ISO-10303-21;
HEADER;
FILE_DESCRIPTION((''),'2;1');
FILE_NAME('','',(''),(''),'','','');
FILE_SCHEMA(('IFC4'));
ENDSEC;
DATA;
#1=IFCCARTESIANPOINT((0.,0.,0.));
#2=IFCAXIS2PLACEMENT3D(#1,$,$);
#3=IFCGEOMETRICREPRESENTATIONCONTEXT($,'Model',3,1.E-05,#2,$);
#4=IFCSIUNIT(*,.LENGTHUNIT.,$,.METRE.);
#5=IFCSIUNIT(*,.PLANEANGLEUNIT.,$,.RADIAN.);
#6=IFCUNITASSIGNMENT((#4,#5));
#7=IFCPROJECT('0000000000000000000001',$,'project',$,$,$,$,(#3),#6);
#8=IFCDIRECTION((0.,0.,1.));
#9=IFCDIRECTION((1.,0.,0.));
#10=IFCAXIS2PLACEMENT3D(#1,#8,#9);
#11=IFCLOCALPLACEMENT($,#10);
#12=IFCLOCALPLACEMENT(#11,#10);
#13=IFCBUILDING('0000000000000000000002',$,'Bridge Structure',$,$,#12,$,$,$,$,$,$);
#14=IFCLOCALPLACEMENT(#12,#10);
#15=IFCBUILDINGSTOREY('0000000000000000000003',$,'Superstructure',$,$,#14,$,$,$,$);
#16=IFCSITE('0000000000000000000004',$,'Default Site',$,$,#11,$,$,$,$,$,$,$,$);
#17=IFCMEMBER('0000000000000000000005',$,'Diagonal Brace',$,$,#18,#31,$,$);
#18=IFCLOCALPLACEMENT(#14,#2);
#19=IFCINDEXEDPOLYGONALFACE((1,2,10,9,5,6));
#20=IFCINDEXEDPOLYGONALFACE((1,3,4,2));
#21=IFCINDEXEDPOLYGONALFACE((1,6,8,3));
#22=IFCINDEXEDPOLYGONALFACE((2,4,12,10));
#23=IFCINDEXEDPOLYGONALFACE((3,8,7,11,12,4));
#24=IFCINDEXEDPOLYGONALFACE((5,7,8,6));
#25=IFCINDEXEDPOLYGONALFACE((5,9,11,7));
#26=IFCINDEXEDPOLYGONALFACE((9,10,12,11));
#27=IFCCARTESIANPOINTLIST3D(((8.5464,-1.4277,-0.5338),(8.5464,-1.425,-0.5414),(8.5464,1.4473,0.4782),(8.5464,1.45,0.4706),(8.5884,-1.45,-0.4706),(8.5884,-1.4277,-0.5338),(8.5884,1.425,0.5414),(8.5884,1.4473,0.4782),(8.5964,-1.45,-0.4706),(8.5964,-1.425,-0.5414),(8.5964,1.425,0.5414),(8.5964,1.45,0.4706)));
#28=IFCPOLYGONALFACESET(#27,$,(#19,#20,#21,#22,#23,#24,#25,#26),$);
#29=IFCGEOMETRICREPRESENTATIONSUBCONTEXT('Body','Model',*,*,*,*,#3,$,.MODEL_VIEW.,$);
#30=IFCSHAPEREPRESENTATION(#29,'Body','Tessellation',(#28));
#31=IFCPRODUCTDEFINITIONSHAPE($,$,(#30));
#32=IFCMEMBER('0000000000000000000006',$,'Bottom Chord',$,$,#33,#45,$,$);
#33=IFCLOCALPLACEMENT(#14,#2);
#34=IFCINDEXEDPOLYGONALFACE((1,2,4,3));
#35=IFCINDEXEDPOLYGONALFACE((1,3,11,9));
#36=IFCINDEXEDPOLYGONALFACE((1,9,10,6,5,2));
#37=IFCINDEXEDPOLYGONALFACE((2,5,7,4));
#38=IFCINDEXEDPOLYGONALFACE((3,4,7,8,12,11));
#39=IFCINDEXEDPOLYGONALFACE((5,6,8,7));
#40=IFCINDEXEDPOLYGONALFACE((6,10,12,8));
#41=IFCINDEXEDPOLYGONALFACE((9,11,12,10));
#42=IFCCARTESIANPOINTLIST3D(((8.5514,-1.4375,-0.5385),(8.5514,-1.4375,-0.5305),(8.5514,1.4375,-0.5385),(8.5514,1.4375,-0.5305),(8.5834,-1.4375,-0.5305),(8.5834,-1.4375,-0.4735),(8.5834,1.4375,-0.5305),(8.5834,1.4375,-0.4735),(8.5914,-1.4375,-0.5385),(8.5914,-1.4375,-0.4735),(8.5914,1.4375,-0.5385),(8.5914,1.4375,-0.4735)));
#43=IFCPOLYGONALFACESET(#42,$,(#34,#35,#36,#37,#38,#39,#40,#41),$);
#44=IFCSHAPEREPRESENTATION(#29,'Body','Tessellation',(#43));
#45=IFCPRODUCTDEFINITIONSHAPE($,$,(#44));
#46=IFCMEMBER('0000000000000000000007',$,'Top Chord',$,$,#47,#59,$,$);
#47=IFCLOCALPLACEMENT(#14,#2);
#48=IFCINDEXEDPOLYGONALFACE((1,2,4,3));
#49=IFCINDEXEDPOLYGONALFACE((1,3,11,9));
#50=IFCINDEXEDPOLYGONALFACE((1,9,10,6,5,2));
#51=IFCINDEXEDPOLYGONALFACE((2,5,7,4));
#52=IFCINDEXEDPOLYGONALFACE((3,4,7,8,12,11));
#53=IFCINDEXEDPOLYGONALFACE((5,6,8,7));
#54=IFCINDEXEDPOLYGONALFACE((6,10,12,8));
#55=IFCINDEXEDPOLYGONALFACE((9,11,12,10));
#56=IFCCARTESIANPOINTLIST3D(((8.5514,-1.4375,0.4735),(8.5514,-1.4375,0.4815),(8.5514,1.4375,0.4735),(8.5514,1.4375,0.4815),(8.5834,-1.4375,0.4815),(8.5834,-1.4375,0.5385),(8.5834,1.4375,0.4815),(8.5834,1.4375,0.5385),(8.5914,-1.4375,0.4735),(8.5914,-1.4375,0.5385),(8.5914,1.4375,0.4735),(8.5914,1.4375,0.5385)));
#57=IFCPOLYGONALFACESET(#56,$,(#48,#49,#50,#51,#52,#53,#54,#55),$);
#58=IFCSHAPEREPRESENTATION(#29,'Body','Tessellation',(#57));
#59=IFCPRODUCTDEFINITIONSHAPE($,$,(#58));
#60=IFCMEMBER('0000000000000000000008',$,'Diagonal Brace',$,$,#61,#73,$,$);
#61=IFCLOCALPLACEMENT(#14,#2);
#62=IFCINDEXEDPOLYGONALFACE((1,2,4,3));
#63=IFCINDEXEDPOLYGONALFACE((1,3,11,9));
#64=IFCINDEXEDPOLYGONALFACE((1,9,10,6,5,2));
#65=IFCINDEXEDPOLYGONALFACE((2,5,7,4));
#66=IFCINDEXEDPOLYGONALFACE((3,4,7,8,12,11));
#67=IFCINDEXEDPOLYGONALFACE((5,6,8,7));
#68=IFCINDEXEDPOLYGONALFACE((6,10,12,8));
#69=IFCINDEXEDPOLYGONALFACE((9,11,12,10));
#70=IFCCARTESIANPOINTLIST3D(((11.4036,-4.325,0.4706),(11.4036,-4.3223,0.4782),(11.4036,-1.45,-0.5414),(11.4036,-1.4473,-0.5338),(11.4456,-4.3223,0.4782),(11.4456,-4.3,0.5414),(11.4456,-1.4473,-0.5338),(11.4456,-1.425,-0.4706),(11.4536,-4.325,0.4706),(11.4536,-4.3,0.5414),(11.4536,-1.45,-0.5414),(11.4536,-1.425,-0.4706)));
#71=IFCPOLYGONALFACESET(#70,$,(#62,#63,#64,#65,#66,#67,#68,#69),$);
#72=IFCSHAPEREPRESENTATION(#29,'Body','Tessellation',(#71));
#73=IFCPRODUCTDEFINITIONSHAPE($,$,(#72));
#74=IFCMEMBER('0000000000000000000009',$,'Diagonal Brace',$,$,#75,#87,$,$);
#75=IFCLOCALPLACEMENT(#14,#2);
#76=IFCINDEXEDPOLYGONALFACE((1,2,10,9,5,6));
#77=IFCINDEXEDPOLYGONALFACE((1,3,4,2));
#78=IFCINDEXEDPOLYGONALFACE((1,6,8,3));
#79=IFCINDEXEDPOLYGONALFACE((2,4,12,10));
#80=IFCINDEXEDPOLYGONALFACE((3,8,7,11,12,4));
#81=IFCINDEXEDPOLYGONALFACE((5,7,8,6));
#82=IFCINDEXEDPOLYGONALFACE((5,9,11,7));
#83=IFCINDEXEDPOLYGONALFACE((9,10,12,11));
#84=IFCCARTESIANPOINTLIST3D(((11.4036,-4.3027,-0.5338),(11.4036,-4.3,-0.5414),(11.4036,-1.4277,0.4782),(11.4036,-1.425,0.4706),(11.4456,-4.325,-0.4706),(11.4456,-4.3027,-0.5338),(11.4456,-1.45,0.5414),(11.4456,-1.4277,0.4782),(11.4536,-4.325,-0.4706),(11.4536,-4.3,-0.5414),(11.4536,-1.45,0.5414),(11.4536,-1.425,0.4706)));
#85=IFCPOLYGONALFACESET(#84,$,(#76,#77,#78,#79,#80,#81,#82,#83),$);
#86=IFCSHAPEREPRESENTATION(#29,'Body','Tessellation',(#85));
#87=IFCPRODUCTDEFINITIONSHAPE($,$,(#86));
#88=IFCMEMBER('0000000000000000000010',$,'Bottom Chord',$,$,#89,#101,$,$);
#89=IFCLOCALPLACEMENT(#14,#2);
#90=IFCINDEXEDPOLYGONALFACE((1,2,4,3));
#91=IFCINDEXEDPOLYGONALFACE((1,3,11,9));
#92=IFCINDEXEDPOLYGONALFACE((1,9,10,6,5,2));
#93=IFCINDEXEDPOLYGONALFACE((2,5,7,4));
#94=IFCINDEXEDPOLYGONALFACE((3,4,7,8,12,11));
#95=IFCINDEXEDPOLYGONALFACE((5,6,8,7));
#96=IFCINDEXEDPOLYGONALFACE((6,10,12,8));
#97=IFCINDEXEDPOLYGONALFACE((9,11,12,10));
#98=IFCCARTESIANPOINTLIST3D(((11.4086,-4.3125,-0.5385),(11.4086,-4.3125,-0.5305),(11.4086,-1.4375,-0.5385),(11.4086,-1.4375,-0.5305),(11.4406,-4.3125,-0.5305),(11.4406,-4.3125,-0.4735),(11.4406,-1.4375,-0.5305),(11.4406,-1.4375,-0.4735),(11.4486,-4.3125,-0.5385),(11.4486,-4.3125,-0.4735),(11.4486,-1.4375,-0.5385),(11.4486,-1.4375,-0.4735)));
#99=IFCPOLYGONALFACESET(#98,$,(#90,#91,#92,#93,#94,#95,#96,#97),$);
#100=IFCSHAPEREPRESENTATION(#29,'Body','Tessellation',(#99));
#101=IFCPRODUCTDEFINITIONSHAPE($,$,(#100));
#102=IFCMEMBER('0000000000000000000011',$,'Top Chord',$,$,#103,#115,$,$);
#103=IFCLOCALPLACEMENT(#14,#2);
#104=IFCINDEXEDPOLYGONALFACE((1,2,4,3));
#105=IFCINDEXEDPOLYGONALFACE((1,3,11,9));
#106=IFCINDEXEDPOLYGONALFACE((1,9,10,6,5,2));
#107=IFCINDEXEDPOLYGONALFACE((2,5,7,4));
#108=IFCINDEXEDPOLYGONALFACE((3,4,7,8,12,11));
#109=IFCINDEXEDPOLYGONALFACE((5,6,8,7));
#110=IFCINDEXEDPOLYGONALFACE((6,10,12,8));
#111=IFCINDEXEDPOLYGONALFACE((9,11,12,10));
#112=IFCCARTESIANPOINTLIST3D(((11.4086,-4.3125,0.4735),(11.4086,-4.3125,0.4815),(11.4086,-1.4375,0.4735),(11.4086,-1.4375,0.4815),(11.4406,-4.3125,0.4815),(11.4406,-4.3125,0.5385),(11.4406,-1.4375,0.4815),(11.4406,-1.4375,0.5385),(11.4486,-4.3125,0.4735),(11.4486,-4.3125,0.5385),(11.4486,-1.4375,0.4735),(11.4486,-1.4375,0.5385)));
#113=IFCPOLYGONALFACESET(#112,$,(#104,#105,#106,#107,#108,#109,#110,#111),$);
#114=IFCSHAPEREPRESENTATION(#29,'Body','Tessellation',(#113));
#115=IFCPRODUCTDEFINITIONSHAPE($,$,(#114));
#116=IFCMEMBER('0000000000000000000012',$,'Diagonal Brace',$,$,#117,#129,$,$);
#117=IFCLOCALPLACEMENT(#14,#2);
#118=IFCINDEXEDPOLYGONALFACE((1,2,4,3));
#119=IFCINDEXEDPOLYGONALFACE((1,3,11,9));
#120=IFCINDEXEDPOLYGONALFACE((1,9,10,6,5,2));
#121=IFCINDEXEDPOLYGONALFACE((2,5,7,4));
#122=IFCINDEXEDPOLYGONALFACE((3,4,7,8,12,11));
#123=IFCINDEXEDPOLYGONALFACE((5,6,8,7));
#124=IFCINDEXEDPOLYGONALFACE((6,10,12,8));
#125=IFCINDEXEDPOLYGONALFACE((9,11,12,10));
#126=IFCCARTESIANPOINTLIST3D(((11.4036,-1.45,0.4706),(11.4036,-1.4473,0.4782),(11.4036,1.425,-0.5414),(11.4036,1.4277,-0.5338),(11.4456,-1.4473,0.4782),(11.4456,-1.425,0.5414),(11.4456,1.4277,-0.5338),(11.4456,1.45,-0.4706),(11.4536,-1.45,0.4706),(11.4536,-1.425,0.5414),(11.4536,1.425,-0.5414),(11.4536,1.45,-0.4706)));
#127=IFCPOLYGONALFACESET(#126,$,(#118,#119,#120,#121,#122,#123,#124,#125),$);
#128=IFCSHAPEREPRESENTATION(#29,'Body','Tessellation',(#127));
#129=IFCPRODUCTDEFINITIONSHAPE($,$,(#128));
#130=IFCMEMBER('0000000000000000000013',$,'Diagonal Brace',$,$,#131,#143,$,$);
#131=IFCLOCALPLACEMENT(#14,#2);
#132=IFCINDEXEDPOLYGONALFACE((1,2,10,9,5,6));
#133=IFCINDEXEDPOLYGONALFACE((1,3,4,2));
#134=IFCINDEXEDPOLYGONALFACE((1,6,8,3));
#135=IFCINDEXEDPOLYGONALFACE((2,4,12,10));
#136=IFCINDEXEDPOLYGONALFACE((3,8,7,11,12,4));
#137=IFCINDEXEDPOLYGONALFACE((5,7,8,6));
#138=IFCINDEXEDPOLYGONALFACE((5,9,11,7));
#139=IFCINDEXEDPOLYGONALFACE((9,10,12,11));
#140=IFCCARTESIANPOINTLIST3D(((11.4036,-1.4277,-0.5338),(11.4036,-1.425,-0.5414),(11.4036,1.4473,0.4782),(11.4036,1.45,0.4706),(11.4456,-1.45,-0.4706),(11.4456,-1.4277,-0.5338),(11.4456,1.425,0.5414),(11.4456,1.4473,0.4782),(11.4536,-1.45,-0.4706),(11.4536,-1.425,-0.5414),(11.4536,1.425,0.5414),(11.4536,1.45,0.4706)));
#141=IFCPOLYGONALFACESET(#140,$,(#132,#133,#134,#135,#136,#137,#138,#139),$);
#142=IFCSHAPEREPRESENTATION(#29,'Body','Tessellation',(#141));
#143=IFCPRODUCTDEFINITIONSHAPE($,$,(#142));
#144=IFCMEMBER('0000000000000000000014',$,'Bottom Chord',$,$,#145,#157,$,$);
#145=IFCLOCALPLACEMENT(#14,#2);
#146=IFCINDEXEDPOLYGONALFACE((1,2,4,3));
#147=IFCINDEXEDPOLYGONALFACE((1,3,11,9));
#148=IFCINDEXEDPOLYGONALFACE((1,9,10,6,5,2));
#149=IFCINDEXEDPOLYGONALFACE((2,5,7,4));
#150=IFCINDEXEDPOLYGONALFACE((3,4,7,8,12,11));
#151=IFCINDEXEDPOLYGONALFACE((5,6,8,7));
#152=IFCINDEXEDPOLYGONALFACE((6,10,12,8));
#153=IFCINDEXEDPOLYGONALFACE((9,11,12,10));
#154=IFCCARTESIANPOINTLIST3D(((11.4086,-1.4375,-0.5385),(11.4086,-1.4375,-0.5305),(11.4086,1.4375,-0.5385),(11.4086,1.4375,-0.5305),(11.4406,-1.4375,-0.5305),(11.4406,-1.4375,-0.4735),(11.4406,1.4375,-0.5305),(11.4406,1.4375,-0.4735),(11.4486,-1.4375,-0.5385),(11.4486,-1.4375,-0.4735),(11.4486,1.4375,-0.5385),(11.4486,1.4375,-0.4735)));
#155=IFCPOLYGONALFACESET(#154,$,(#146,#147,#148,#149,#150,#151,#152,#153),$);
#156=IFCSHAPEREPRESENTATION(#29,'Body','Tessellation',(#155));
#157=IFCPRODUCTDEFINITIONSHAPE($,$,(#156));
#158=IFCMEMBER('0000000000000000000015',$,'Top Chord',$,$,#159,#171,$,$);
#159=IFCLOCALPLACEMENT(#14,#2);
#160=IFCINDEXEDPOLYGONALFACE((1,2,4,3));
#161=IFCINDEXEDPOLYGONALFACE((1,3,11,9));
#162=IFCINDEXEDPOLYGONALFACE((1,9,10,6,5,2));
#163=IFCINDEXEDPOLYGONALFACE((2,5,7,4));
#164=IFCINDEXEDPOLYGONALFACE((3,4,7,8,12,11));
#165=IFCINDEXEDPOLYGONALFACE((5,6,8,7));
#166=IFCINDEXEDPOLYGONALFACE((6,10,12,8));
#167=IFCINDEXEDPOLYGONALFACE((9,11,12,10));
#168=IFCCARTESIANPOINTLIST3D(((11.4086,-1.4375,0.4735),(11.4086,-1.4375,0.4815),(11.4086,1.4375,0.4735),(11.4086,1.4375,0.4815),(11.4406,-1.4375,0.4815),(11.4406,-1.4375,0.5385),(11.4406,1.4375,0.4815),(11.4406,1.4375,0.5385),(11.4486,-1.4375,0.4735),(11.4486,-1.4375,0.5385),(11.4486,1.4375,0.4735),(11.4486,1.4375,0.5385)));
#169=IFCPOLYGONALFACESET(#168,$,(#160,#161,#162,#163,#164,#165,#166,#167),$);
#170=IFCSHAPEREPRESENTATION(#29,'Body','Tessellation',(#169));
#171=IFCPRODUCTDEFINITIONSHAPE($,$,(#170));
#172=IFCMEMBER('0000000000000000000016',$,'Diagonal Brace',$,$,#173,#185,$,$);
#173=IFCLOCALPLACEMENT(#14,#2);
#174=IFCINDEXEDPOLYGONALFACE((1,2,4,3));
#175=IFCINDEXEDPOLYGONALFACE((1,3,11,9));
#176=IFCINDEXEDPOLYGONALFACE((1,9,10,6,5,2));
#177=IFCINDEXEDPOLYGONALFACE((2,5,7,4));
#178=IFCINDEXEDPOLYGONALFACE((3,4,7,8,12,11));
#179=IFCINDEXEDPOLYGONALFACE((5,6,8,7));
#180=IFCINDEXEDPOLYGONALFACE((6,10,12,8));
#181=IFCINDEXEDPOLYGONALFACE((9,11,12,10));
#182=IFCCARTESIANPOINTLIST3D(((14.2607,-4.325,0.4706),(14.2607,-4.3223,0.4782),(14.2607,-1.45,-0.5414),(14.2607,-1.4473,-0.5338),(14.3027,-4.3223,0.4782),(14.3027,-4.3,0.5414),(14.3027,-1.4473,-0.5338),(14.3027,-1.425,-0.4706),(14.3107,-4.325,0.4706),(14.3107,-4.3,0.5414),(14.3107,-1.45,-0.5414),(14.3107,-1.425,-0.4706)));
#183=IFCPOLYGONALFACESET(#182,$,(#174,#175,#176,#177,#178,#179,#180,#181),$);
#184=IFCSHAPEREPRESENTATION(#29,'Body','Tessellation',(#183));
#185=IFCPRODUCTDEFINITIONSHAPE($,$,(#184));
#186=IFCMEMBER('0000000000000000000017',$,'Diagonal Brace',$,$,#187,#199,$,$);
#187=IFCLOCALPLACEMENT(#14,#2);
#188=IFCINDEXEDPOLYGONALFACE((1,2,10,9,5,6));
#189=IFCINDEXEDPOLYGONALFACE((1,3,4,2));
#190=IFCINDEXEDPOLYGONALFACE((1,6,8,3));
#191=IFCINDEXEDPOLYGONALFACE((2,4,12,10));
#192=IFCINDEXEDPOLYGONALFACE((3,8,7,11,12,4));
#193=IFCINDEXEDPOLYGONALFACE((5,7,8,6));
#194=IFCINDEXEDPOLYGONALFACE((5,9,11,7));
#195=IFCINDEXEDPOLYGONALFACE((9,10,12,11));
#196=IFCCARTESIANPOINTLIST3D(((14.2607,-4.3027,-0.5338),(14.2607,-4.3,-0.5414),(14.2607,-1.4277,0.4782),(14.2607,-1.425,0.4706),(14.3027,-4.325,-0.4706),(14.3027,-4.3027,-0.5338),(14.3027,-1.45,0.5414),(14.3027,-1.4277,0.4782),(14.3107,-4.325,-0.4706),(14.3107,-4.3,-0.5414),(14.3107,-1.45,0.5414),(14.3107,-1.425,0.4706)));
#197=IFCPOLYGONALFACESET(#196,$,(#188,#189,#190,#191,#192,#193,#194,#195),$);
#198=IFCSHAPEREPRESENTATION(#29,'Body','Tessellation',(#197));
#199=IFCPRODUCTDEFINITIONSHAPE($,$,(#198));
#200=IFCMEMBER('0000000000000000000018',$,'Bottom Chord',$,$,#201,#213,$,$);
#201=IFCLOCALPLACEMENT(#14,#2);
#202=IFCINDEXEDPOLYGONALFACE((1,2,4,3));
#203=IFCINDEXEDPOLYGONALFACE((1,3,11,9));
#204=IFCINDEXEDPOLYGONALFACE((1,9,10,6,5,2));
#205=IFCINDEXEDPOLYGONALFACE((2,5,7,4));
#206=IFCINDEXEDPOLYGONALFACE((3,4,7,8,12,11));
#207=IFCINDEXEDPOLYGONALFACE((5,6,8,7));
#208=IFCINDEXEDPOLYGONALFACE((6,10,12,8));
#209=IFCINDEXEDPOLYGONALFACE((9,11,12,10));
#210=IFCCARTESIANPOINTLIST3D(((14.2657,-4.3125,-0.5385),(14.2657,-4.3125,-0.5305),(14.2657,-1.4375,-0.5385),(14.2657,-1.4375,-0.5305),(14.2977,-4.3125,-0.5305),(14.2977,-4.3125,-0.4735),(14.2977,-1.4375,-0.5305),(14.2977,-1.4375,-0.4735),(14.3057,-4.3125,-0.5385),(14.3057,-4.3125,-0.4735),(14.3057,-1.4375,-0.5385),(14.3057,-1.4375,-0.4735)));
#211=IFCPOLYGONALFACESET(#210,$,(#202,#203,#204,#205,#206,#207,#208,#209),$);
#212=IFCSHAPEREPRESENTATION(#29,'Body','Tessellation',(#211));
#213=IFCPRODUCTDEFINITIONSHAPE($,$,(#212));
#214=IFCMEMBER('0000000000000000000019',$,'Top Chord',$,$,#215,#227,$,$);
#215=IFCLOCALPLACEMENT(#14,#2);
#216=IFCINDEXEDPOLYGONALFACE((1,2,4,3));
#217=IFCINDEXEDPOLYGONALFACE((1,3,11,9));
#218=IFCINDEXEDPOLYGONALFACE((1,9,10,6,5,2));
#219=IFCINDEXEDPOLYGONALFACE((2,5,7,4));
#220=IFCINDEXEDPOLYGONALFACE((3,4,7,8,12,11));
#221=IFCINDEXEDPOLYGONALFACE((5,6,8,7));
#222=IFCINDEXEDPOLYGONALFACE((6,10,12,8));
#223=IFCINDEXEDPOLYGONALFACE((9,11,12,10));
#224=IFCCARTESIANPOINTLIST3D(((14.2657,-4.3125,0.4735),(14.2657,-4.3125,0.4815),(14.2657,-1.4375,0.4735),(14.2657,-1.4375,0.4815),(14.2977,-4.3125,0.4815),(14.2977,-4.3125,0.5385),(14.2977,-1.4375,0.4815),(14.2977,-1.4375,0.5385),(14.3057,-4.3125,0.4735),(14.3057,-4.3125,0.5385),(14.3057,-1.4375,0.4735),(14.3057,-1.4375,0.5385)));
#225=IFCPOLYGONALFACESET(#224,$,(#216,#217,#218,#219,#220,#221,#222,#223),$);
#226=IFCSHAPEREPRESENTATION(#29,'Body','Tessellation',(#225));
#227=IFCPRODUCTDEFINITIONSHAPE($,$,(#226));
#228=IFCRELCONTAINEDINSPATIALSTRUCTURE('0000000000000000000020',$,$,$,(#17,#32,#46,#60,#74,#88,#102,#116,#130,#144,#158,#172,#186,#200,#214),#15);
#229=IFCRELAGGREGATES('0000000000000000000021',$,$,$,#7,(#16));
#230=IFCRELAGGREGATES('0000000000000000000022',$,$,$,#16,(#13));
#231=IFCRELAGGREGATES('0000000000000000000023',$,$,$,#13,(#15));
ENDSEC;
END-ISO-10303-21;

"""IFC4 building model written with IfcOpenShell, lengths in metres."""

from ifc_helpers import new_model, si_unit, frame, origin, origin_with_axes, origin_2d_with_axis, place, context, subcontext, project, spatial, l_section, extrude, element, save


model = new_model("IFC4")

# Units and contexts
model_context = context("Model", 3, precision=1e-05, world=origin())
body_context = subcontext(model_context, "Body", "Model", "MODEL_VIEW")
ifc_project = project(units=[si_unit("LENGTHUNIT", "METRE"), si_unit("PLANEANGLEUNIT", "RADIAN")], contexts=[model_context])

# Site, building, storey
site_placement = place(None, origin_with_axes())
site = spatial("IfcSite", under=ifc_project, at=site_placement, Name="Default Site")
building_placement = place(site_placement, origin_with_axes())
building = spatial("IfcBuilding", under=site, at=building_placement, Name="Bridge Structure")
storey_placement = place(building_placement, origin_with_axes())
storey = spatial("IfcBuildingStorey", under=building, at=storey_placement, Name="Superstructure")

# Members
member_placement = place(storey_placement, frame((8.5714, -1.4375, -0.506), z_axis=(0.0, 0.943269, 0.332031), x_axis=(-1.0, 0.0, 0.0)))
element("IfcMember", 1, at=member_placement, inside=storey, Name="Diagonal Brace", context=body_context, shape_type="SweptSolid", body=[
    extrude(l_section(Depth=0.075, Width=0.05, Thickness=0.008, at=origin_2d_with_axis()), origin_with_axes(), (0.0, 0.0, 1.0), 3.0479),
])
for number, where, z_axis, x_axis, name in (
    (2, (8.5714, -1.4375, -0.506), (0.0, 1.0, 0.0), (-1.0, 0.0, 0.0), "Bottom Chord"),
    (3, (8.5714, -1.4375, 0.506), (0.0, 1.0, 0.0), (-1.0, 0.0, 0.0), "Top Chord"),
):
    element("IfcMember", number, at=place(storey_placement, frame(where, z_axis=z_axis, x_axis=x_axis)), inside=storey, Name=name, context=body_context, shape_type="SweptSolid", body=[
        extrude(l_section(Depth=0.065, Width=0.04, Thickness=0.008, at=origin_2d_with_axis()), origin_with_axes(), (0.0, 0.0, 1.0), 2.875),
    ])
for number, where, z_axis, x_axis, name in (
    (4, (11.4286, -4.3125, 0.506), (0.0, 0.943269, -0.332031), (-1.0, 0.0, 0.0), "Diagonal Brace"),
    (5, (11.4286, -4.3125, -0.506), (0.0, 0.943269, 0.332031), (-1.0, 0.0, 0.0), "Diagonal Brace"),
):
    element("IfcMember", number, at=place(storey_placement, frame(where, z_axis=z_axis, x_axis=x_axis)), inside=storey, Name=name, context=body_context, shape_type="SweptSolid", body=[
        extrude(l_section(Depth=0.075, Width=0.05, Thickness=0.008, at=origin_2d_with_axis()), origin_with_axes(), (0.0, 0.0, 1.0), 3.0479),
    ])
for number, where, z_axis, x_axis, name in (
    (6, (11.4286, -4.3125, -0.506), (0.0, 1.0, 0.0), (-1.0, 0.0, 0.0), "Bottom Chord"),
    (7, (11.4286, -4.3125, 0.506), (0.0, 1.0, 0.0), (-1.0, 0.0, 0.0), "Top Chord"),
):
    element("IfcMember", number, at=place(storey_placement, frame(where, z_axis=z_axis, x_axis=x_axis)), inside=storey, Name=name, context=body_context, shape_type="SweptSolid", body=[
        extrude(l_section(Depth=0.065, Width=0.04, Thickness=0.008, at=origin_2d_with_axis()), origin_with_axes(), (0.0, 0.0, 1.0), 2.875),
    ])
for number, where, z_axis, x_axis, name in (
    (8, (11.4286, -1.4375, 0.506), (0.0, 0.943269, -0.332031), (-1.0, 0.0, 0.0), "Diagonal Brace"),
    (9, (11.4286, -1.4375, -0.506), (0.0, 0.943269, 0.332031), (-1.0, 0.0, 0.0), "Diagonal Brace"),
):
    element("IfcMember", number, at=place(storey_placement, frame(where, z_axis=z_axis, x_axis=x_axis)), inside=storey, Name=name, context=body_context, shape_type="SweptSolid", body=[
        extrude(l_section(Depth=0.075, Width=0.05, Thickness=0.008, at=origin_2d_with_axis()), origin_with_axes(), (0.0, 0.0, 1.0), 3.0479),
    ])
for number, where, z_axis, x_axis, name in (
    (10, (11.4286, -1.4375, -0.506), (0.0, 1.0, 0.0), (-1.0, 0.0, 0.0), "Bottom Chord"),
    (11, (11.4286, -1.4375, 0.506), (0.0, 1.0, 0.0), (-1.0, 0.0, 0.0), "Top Chord"),
):
    element("IfcMember", number, at=place(storey_placement, frame(where, z_axis=z_axis, x_axis=x_axis)), inside=storey, Name=name, context=body_context, shape_type="SweptSolid", body=[
        extrude(l_section(Depth=0.065, Width=0.04, Thickness=0.008, at=origin_2d_with_axis()), origin_with_axes(), (0.0, 0.0, 1.0), 2.875),
    ])
for number, where, z_axis, x_axis, name in (
    (12, (14.2857, -4.3125, 0.506), (0.0, 0.943269, -0.332031), (-1.0, 0.0, 0.0), "Diagonal Brace"),
    (13, (14.2857, -4.3125, -0.506), (0.0, 0.943269, 0.332031), (-1.0, 0.0, 0.0), "Diagonal Brace"),
):
    element("IfcMember", number, at=place(storey_placement, frame(where, z_axis=z_axis, x_axis=x_axis)), inside=storey, Name=name, context=body_context, shape_type="SweptSolid", body=[
        extrude(l_section(Depth=0.075, Width=0.05, Thickness=0.008, at=origin_2d_with_axis()), origin_with_axes(), (0.0, 0.0, 1.0), 3.0479),
    ])
for number, where, z_axis, x_axis, name in (
    (14, (14.2857, -4.3125, -0.506), (0.0, 1.0, 0.0), (-1.0, 0.0, 0.0), "Bottom Chord"),
    (15, (14.2857, -4.3125, 0.506), (0.0, 1.0, 0.0), (-1.0, 0.0, 0.0), "Top Chord"),
):
    element("IfcMember", number, at=place(storey_placement, frame(where, z_axis=z_axis, x_axis=x_axis)), inside=storey, Name=name, context=body_context, shape_type="SweptSolid", body=[
        extrude(l_section(Depth=0.065, Width=0.04, Thickness=0.008, at=origin_2d_with_axis()), origin_with_axes(), (0.0, 0.0, 1.0), 2.875),
    ])

save(model, "model.ifc")
